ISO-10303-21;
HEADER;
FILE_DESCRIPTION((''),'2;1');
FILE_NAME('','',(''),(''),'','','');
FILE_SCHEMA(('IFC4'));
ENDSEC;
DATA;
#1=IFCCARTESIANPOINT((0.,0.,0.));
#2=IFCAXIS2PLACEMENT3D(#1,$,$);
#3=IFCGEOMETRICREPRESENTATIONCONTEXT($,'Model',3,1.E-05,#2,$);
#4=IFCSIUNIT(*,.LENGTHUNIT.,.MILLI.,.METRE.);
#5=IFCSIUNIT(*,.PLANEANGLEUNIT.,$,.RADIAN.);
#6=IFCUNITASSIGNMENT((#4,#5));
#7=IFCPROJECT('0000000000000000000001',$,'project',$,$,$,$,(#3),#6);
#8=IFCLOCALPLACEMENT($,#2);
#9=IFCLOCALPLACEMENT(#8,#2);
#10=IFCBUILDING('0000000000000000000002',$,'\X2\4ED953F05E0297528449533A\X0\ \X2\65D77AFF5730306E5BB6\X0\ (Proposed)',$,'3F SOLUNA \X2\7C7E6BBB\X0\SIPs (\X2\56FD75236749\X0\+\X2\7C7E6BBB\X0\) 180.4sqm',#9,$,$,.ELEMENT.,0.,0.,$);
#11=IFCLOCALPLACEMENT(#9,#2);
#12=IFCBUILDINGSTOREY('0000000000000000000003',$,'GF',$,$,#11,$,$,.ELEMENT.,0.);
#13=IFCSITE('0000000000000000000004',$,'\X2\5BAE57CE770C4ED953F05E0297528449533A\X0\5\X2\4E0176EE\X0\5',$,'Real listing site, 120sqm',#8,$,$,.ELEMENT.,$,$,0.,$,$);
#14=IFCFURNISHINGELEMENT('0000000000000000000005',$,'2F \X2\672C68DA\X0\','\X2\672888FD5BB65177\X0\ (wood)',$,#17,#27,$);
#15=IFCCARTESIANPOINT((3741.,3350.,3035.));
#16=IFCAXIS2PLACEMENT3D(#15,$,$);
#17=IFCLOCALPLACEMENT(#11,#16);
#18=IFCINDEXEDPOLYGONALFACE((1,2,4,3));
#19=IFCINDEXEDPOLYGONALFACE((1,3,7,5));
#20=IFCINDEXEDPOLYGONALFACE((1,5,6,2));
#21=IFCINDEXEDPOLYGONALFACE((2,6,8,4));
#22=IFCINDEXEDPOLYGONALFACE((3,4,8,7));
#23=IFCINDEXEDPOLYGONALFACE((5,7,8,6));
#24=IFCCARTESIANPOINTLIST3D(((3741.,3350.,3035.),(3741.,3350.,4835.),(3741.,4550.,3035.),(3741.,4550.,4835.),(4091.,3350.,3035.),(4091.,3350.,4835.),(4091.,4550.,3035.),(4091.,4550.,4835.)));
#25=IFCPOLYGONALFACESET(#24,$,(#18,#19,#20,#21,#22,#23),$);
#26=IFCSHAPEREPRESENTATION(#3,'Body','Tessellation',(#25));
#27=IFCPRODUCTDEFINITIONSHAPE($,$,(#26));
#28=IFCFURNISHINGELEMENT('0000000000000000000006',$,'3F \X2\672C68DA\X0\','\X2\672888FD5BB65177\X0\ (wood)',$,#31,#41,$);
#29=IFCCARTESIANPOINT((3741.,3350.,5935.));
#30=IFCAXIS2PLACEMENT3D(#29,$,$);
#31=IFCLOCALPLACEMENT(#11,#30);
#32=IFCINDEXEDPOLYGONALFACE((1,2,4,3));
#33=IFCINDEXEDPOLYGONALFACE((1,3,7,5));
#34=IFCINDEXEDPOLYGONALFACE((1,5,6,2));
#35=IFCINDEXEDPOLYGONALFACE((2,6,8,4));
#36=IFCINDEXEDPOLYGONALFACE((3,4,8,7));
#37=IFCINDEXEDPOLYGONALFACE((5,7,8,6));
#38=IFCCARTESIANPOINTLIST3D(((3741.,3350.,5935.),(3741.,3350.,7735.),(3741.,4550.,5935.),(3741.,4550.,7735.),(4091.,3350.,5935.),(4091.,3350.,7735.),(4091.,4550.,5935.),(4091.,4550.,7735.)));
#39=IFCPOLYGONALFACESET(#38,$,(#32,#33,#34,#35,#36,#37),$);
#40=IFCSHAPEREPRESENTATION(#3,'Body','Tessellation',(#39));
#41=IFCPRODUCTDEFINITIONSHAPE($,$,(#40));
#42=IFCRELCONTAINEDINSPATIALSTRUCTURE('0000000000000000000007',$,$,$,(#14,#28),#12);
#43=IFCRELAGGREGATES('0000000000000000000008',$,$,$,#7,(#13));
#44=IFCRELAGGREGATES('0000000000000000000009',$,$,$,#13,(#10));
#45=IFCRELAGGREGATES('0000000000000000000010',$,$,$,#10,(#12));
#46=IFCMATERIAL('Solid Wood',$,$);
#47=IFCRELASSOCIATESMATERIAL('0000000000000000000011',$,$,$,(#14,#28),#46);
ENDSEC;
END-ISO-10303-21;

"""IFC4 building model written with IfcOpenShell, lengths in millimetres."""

from ifc_helpers import new_model, si_unit, frame, frame_2d, origin, place, context, project, spatial, rectangle, extrude, material, element, save


model = new_model("IFC4")

# Units and contexts
model_context = context("Model", 3, precision=1e-05, world=origin())
ifc_project = project(units=[si_unit("LENGTHUNIT", "METRE", prefix="MILLI"), si_unit("PLANEANGLEUNIT", "RADIAN")], contexts=[model_context])

# Site, building, storey
site_placement = place(None, origin())
site = spatial("IfcSite", under=ifc_project, at=site_placement, Name="宮城県仙台市青葉区5丁目5", ObjectType="Real listing site, 120sqm", CompositionType="ELEMENT", RefElevation=0.0)
building_placement = place(site_placement, origin())
building = spatial("IfcBuilding", under=site, at=building_placement, Name="仙台市青葉区 旗竿地の家 (Proposed)", ObjectType="3F SOLUNA 籾殻SIPs (国産杉+籾殻) 180.4sqm", CompositionType="ELEMENT", ElevationOfRefHeight=0.0, ElevationOfTerrain=0.0)
storey_placement = place(building_placement, origin())
storey = spatial("IfcBuildingStorey", under=building, at=storey_placement, Name="GF", CompositionType="ELEMENT", Elevation=0.0)

# Shared definitions
ifc_material_1 = material(Name="Solid Wood")

# Furnishing elements
furnishing_1_placement = place(storey_placement, frame((3741.0, 3350.0, 3035.0)))
element("IfcFurnishingElement", 1, at=furnishing_1_placement, inside=storey, material=ifc_material_1, Name="2F 本棚", Description="木製家具 (wood)", context=model_context, shape_type="SweptSolid", body=[
    extrude(rectangle(XDim=350.0, YDim=1200.0, at=frame_2d((175.0, 600.0))), frame((3741.0, 3350.0, 3035.0)), (0.0, 0.0, 1.0), 1800.0),
])
furnishing_2_placement = place(storey_placement, frame((3741.0, 3350.0, 5935.0)))
element("IfcFurnishingElement", 2, at=furnishing_2_placement, inside=storey, material=ifc_material_1, Name="3F 本棚", Description="木製家具 (wood)", context=model_context, shape_type="SweptSolid", body=[
    extrude(rectangle(XDim=350.0, YDim=1200.0, at=frame_2d((175.0, 600.0))), frame((3741.0, 3350.0, 5935.0)), (0.0, 0.0, 1.0), 1800.0),
])

save(model, "model.ifc")
